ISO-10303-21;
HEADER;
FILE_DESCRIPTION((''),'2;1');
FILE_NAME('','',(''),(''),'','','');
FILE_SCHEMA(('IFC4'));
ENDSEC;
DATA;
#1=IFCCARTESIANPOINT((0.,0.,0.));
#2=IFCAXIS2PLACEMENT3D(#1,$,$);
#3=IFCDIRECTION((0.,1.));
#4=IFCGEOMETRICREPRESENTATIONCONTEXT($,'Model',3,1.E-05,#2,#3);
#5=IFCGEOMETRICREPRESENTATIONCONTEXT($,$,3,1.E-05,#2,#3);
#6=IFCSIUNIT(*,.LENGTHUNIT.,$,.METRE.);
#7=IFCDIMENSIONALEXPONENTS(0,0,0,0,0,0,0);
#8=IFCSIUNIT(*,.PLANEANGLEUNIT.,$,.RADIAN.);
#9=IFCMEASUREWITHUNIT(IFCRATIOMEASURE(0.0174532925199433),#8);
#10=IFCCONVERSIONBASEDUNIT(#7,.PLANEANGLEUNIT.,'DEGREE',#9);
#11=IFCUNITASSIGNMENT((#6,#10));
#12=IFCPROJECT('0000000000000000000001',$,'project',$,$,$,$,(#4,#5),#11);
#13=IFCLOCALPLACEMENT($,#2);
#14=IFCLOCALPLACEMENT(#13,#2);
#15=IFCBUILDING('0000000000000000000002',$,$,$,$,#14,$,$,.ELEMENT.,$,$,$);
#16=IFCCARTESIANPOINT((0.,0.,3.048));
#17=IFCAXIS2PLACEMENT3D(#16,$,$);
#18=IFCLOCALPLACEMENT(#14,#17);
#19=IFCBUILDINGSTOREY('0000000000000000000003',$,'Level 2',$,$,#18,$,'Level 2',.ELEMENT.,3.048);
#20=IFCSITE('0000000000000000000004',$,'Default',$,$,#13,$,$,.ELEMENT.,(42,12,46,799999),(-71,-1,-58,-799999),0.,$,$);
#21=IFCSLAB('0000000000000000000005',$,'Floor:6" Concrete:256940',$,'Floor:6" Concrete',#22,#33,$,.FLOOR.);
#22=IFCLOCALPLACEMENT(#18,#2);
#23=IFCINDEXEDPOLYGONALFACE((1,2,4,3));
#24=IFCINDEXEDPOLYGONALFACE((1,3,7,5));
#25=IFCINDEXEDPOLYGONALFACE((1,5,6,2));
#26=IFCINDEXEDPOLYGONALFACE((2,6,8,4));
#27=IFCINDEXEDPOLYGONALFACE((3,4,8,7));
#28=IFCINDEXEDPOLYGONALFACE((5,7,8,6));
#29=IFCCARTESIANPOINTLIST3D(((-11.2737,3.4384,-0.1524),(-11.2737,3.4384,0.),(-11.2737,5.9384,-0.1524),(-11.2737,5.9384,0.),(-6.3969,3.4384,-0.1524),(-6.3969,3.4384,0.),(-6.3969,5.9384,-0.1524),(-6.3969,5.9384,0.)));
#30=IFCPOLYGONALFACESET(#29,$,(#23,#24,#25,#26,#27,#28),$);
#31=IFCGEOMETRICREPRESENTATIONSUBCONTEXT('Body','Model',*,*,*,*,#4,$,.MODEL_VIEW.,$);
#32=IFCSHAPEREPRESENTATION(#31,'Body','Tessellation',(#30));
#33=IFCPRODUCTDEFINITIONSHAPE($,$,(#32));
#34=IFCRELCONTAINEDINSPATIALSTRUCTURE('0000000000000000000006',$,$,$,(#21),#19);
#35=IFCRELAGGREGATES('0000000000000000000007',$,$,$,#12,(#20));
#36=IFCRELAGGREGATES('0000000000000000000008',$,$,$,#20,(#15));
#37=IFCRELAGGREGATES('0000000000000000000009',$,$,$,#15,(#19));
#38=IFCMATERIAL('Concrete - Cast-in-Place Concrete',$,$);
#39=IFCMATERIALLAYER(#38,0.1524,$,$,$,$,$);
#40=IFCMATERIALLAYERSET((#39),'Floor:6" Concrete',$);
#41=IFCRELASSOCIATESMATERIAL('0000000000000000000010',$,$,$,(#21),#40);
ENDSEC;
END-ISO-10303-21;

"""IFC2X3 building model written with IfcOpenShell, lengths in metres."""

from ifc_helpers import new_model, entity, si_unit, converted_unit, direction, frame, frame_2d, origin, place, context, subcontext, project, spatial, rectangle, extrude, material, layer, layer_set, layer_usage, element, save


model = new_model("IFC2X3")

# Units and contexts
model_context = context("Model", 3, precision=1e-05, world=origin(), true_north=direction((0.0, 1.0)))
context_of_model = context(None, 3, precision=1e-05, world=origin(), true_north=direction((0.0, 1.0)))
body_context = subcontext(model_context, "Body", "Model", "MODEL_VIEW")
ifc_project = project(units=[si_unit("LENGTHUNIT", "METRE"), converted_unit("PLANEANGLEUNIT", "DEGREE", entity("IfcRatioMeasure", 0.0174532925199433), si_unit("PLANEANGLEUNIT", "RADIAN"), dimensions=[0, 0, 0, 0, 0, 0, 0])], contexts=[model_context, context_of_model])

# Site, building, storey
site_placement = place(None, origin())
site = spatial("IfcSite", under=ifc_project, at=site_placement, Name="Default", CompositionType="ELEMENT", RefLatitude=(42, 12, 46, 799999), RefLongitude=(-71, -1, -58, -799999), RefElevation=0.0)
building_placement = place(site_placement, origin())
building = spatial("IfcBuilding", under=site, at=building_placement, CompositionType="ELEMENT")
storey_placement = place(building_placement, frame((0.0, 0.0, 3.048)))
storey = spatial("IfcBuildingStorey", under=building, at=storey_placement, Name="Level 2", LongName="Level 2", CompositionType="ELEMENT", Elevation=3.048)

# Shared definitions
ifc_material = material(Name="Concrete - Cast-in-Place Concrete")

# Slab
ifc_layer = layer(ifc_material, 0.1524)
ifc_layer_set = layer_set([ifc_layer], Name="Floor:6\" Concrete")
ifc_layer_usage = layer_usage(ifc_layer_set, "AXIS3", "POSITIVE", 0.0)
slab_placement = place(storey_placement, origin())
element("IfcSlab", 1, at=slab_placement, inside=storey, material=ifc_layer_usage, Name="Floor:6\" Concrete:256940", ObjectType="Floor:6\" Concrete", PredefinedType="FLOOR", context=body_context, shape_type="SweptSolid", body=[
    extrude(rectangle(XDim=2.5, YDim=4.8768, at=frame_2d((0.0, 0.0), x_axis=(1.0, 0.0))), frame((-8.8353, 4.6884, 0.0), z_axis=(0.0, 0.0, -1.0), x_axis=(0.0, 1.0, 0.0)), (0.0, 0.0, 1.0), 0.1524),
])

save(model, "model.ifc")
